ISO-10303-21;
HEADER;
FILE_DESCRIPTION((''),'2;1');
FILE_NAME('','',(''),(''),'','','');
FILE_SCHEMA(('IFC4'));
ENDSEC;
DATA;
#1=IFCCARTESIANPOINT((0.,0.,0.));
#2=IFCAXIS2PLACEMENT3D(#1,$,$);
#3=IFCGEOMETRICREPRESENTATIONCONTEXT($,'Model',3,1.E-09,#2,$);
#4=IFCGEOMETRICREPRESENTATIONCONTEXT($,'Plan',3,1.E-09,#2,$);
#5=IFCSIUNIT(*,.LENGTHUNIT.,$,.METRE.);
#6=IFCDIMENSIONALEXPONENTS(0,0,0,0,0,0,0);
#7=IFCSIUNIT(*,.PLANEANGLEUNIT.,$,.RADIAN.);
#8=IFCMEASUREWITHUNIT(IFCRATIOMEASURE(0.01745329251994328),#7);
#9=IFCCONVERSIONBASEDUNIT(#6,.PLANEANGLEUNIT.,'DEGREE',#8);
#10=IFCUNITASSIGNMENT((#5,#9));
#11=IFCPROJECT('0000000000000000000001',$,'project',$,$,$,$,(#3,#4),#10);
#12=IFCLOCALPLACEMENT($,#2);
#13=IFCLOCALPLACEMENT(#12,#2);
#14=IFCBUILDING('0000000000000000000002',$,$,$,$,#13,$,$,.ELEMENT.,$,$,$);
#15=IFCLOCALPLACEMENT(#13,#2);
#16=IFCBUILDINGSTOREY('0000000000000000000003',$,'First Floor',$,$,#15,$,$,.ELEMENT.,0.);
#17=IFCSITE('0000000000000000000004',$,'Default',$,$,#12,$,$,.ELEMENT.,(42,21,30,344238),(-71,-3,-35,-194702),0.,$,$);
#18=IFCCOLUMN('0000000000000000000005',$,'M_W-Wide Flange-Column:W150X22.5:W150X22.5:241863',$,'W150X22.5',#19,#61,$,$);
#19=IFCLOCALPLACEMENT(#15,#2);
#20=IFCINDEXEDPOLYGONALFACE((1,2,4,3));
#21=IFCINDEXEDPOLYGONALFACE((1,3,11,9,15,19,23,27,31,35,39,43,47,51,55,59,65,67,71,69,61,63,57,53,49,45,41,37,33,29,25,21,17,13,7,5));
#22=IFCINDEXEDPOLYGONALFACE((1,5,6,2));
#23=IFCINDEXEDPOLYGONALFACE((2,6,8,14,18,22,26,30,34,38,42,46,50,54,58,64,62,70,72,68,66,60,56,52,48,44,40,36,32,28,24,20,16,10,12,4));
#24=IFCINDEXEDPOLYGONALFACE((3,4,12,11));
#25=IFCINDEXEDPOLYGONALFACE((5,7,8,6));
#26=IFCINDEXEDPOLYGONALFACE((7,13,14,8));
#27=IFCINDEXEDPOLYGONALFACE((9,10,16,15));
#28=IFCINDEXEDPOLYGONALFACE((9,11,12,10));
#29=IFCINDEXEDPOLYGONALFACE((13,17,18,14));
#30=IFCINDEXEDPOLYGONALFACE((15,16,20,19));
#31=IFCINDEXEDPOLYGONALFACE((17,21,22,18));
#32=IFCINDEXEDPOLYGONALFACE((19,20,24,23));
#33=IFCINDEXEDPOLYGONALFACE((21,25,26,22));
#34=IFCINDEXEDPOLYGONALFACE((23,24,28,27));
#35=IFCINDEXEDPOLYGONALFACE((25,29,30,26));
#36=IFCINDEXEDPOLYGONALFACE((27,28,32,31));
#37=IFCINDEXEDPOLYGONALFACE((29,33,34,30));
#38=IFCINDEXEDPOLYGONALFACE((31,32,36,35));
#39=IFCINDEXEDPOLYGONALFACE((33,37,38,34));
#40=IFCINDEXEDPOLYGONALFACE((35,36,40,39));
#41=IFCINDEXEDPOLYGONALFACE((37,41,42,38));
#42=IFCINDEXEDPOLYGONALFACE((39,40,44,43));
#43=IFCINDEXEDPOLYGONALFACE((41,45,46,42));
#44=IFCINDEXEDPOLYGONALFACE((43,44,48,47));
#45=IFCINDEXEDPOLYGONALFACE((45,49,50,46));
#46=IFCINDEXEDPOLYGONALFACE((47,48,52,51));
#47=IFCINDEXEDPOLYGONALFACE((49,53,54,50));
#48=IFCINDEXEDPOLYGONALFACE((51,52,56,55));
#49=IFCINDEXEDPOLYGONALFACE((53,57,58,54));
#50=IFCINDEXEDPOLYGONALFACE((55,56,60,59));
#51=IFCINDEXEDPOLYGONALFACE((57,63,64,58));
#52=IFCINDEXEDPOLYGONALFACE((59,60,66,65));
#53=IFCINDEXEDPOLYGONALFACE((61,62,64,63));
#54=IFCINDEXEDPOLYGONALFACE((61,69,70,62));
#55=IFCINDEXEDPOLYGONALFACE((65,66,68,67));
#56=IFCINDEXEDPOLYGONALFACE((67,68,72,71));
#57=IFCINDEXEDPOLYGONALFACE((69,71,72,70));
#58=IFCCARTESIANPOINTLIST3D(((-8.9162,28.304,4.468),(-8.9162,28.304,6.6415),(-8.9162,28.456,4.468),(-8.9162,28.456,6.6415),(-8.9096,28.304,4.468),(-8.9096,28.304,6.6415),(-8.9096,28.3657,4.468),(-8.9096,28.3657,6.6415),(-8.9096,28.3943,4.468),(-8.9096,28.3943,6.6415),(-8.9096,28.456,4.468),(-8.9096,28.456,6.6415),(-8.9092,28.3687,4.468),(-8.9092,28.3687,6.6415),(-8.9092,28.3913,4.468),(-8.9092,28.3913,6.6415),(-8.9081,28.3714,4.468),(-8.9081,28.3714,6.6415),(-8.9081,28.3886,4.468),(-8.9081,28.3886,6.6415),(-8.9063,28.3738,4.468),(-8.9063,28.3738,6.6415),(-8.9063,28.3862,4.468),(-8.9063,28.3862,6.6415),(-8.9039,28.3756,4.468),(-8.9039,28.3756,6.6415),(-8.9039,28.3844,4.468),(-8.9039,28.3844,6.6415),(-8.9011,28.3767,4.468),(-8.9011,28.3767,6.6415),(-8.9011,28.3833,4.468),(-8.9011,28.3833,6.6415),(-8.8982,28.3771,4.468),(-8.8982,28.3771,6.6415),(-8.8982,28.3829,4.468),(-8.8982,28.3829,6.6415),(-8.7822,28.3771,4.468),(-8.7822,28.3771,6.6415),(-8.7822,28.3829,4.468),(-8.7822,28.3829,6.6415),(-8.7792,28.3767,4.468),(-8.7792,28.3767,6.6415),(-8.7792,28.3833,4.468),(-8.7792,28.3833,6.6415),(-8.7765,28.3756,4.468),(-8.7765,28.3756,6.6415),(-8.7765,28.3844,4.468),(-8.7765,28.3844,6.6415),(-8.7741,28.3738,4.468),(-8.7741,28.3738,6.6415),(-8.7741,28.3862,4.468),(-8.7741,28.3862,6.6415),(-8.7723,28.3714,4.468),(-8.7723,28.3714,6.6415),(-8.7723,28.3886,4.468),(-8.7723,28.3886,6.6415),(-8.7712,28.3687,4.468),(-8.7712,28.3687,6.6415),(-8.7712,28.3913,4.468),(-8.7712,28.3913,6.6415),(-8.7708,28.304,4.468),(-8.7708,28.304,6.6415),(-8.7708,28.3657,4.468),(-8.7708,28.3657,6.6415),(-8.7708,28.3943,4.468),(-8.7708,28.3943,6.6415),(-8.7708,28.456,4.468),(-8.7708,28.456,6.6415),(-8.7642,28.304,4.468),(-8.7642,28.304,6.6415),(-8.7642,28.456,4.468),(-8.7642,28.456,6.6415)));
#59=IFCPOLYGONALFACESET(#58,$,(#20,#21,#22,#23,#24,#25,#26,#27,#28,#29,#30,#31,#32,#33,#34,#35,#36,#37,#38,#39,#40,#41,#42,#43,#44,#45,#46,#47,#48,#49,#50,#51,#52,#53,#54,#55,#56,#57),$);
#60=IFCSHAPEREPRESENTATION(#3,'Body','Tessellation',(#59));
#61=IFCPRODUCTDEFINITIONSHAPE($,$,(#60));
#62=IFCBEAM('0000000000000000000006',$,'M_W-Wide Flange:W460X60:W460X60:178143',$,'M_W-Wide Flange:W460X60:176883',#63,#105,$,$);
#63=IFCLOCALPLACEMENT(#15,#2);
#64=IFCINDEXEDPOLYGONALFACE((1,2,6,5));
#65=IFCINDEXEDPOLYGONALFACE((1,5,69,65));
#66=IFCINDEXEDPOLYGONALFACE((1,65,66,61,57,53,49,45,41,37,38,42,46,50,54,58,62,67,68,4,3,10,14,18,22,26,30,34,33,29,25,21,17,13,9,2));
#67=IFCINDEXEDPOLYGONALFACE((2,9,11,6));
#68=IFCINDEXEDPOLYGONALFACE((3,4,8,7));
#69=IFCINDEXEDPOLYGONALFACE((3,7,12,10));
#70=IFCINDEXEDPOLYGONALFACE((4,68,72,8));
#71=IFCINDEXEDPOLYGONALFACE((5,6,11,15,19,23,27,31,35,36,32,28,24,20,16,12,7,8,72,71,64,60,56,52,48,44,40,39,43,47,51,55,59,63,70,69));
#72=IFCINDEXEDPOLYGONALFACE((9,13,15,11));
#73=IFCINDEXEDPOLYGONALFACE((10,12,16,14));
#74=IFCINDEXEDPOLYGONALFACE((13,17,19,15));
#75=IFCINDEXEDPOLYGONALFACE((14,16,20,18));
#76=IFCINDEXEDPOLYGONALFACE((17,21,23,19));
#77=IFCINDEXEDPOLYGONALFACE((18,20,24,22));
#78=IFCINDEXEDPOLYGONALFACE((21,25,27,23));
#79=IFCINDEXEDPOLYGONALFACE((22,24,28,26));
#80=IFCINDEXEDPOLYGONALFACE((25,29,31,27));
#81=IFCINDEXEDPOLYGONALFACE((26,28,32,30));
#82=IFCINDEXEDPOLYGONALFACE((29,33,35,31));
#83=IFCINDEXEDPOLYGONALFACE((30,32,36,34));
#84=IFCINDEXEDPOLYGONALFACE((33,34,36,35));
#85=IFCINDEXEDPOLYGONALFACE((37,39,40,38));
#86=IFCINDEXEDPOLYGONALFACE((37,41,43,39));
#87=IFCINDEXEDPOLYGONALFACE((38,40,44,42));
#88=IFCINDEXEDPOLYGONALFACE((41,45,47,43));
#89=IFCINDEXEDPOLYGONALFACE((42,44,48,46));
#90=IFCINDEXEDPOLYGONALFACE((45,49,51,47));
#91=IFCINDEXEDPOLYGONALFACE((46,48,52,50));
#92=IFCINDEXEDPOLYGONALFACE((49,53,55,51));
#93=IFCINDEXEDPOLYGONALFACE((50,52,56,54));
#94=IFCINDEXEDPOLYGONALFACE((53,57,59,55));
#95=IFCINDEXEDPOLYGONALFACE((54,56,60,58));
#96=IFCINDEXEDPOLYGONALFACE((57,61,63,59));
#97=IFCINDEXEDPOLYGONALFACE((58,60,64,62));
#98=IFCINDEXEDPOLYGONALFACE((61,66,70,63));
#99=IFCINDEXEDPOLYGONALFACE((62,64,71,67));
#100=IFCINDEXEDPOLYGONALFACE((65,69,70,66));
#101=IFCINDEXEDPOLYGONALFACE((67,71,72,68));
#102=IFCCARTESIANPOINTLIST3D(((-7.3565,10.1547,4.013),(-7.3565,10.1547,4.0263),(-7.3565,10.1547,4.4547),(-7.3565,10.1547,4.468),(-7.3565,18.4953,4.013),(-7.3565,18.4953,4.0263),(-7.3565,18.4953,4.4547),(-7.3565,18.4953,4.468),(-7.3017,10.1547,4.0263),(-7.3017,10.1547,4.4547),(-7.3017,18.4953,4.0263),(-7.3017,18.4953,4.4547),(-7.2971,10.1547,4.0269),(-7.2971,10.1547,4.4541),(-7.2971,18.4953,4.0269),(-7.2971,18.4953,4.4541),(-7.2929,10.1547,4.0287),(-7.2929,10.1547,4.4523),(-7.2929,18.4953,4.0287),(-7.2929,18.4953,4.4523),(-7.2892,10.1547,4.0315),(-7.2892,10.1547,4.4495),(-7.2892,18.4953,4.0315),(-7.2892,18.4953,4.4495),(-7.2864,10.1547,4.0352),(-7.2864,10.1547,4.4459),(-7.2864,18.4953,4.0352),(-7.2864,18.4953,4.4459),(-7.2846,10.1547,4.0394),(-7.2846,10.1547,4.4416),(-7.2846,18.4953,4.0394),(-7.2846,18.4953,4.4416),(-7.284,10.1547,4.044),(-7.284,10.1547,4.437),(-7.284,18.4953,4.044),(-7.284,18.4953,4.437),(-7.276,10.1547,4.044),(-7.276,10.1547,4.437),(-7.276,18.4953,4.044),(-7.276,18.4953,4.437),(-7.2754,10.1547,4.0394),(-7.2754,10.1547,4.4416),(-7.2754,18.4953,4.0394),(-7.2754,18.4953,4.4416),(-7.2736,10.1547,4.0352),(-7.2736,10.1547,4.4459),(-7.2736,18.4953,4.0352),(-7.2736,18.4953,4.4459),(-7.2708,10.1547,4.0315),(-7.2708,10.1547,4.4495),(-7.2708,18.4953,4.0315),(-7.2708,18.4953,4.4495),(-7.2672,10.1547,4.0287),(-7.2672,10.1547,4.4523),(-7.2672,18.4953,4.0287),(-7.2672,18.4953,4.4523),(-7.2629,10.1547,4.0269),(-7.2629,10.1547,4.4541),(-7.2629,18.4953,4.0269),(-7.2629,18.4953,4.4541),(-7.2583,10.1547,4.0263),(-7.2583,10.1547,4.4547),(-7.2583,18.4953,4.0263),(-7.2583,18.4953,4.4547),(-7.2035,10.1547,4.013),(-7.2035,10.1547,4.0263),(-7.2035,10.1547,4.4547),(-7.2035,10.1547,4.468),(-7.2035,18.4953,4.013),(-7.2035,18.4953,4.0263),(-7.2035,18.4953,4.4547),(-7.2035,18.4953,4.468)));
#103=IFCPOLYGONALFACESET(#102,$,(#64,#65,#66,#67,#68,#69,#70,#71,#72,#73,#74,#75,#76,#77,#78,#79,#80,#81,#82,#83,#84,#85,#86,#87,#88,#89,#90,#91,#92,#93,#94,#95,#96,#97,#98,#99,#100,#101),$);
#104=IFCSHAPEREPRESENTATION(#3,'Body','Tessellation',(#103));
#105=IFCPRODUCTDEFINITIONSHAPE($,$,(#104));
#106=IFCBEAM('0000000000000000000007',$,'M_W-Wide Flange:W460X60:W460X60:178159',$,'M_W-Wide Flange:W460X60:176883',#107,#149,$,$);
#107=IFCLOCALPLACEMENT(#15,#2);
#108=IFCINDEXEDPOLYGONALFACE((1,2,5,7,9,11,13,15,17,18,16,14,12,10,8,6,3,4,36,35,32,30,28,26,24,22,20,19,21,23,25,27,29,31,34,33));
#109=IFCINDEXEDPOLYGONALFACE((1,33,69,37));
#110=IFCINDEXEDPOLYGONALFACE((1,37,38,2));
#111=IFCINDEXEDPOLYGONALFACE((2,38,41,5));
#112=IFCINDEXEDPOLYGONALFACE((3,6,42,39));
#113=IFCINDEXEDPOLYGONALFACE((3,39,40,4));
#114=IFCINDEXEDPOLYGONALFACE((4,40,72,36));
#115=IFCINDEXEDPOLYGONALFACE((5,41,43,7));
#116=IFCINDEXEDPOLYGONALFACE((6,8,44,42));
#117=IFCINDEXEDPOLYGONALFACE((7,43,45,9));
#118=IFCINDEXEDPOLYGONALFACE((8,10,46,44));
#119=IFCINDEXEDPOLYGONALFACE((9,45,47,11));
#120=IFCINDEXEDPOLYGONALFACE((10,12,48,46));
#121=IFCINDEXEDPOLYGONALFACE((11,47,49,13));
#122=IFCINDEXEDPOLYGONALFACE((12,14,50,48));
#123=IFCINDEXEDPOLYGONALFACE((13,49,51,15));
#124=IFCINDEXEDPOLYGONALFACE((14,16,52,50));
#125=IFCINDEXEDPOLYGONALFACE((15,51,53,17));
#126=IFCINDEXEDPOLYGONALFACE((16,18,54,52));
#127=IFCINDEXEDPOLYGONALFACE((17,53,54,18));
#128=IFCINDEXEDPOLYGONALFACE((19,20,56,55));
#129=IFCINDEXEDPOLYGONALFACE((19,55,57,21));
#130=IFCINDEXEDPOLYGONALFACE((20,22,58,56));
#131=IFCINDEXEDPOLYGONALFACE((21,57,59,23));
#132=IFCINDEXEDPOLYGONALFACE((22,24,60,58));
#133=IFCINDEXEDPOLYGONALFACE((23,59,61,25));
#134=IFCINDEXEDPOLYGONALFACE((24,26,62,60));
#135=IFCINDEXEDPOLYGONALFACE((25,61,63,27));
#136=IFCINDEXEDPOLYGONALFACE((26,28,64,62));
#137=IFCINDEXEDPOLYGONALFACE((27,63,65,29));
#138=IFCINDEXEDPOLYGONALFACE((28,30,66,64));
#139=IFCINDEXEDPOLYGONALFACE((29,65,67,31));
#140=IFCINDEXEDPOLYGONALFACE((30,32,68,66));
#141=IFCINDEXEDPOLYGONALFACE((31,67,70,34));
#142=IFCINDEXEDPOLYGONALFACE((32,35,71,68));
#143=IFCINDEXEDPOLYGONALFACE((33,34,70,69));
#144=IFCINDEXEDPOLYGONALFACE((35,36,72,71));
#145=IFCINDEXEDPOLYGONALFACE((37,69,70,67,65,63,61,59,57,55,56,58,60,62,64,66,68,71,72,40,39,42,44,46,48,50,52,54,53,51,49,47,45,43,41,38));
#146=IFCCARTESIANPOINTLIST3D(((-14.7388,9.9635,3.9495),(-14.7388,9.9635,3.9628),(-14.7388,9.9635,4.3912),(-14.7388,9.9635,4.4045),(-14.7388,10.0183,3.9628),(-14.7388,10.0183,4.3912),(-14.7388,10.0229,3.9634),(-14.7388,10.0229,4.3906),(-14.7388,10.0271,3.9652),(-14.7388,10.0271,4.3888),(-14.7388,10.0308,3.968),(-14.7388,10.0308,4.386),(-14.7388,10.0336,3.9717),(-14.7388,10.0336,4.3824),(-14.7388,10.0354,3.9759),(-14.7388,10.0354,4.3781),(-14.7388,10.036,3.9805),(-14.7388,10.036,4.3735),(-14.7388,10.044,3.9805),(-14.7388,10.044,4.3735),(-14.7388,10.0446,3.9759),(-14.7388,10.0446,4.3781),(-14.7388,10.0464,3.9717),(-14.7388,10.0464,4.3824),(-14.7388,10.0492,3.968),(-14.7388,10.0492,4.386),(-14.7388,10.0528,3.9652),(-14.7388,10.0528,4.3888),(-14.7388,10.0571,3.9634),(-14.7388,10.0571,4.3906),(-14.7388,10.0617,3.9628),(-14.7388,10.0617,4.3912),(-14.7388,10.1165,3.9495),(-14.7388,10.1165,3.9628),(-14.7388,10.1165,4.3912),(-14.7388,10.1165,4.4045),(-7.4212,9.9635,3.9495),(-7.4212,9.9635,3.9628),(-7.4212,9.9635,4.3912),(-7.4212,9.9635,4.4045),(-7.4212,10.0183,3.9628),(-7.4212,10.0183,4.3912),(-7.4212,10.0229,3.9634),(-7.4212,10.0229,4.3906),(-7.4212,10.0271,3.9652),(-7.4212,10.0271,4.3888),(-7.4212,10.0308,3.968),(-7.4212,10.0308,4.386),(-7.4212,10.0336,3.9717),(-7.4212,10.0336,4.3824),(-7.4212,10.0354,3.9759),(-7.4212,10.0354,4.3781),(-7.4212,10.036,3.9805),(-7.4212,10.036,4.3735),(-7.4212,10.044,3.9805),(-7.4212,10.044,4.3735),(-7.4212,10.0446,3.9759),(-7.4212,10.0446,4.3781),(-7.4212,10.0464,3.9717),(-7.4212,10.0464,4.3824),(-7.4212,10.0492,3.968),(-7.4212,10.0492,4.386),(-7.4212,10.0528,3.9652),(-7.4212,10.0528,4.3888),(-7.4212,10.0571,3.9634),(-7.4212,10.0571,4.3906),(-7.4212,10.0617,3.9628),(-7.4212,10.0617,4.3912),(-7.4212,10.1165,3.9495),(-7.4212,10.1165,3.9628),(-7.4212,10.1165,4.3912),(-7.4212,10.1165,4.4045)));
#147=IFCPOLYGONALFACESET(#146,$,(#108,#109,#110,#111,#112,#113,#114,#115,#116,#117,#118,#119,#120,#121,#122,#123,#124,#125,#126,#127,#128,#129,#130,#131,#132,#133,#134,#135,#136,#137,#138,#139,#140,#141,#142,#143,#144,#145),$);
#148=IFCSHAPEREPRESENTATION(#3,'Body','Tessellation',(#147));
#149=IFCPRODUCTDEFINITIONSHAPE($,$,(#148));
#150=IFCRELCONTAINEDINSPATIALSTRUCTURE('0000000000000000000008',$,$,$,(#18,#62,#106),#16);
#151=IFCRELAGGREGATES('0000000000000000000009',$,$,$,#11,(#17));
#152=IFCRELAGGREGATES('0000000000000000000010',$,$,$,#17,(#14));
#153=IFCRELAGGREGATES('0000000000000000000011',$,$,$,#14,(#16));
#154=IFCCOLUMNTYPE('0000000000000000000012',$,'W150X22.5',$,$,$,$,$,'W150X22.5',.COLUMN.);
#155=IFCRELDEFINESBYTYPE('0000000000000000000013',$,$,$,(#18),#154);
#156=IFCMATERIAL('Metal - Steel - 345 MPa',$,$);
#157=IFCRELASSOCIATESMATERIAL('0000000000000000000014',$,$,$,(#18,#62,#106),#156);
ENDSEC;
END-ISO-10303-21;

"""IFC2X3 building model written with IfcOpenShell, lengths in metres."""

from ifc_helpers import new_model, entity, si_unit, converted_unit, frame, frame_2d, origin, place, context, project, spatial, polyline, circle_curve, parameter, trimmed, segment, composite_curve, outline, extrude, source, transform, mapped, material, type_object, type_shapes, element, save


model = new_model("IFC2X3")

# Units and contexts
model_context = context("Model", 3, precision=1e-09, world=origin())
plan_context = context("Plan", 3, precision=1e-09, world=origin())
ifc_project = project(units=[si_unit("LENGTHUNIT", "METRE"), converted_unit("PLANEANGLEUNIT", "DEGREE", entity("IfcRatioMeasure", 0.01745329251994328), si_unit("PLANEANGLEUNIT", "RADIAN"), dimensions=[0, 0, 0, 0, 0, 0, 0])], contexts=[model_context, plan_context])

# Site, building, storey
site_placement = place(None, origin())
site = spatial("IfcSite", under=ifc_project, at=site_placement, Name="Default", CompositionType="ELEMENT", RefLatitude=(42, 21, 30, 344238), RefLongitude=(-71, -3, -35, -194702), RefElevation=0.0)
building_placement = place(site_placement, origin())
building = spatial("IfcBuilding", under=site, at=building_placement, CompositionType="ELEMENT")
storey_placement = place(building_placement, origin())
storey = spatial("IfcBuildingStorey", under=building, at=storey_placement, Name="First Floor", CompositionType="ELEMENT", Elevation=0.0)

# Column
ifc_material = material(Name="Metal - Steel - 345 MPa")
column_type = type_object("IfcColumnType", Name="W150X22.5", ElementType="W150X22.5", PredefinedType="COLUMN")
shared_shape = source(origin(), model_context, "Body", "SweptSolid", [
    extrude(outline(composite_curve([segment(polyline([(-0.076, -0.076), (0.076, -0.076)]), True, "CONTINUOUS"), segment(polyline([(0.076, -0.076), (0.076, -0.0694)]), True, "CONTINUOUS"), segment(polyline([(0.076, -0.0694), (0.0143, -0.0694)]), True, "CONTINUOUS"), segment(trimmed(circle_curve(frame_2d((0.0143, -0.058), x_axis=(-1.0, 0.0)), 0.0114), [parameter(0.0)], [parameter(90.0)], True, "PARAMETER"), False, "CONTINUOUS"), segment(polyline([(0.0029, -0.058), (0.0029, 0.058)]), True, "CONTINUOUS"), segment(trimmed(circle_curve(frame_2d((0.0143, 0.058), x_axis=(-1.0, 0.0)), 0.0114), [parameter(270.0)], [parameter(0.0)], True, "PARAMETER"), False, "CONTINUOUS"), segment(polyline([(0.0143, 0.0694), (0.076, 0.0694)]), True, "CONTINUOUS"), segment(polyline([(0.076, 0.0694), (0.076, 0.076)]), True, "CONTINUOUS"), segment(polyline([(0.076, 0.076), (-0.076, 0.076)]), True, "CONTINUOUS"), segment(polyline([(-0.076, 0.076), (-0.076, 0.0694)]), True, "CONTINUOUS"), segment(polyline([(-0.076, 0.0694), (-0.0143, 0.0694)]), True, "CONTINUOUS"), segment(trimmed(circle_curve(frame_2d((-0.0143, 0.058), x_axis=(-1.0, 0.0)), 0.0114), [parameter(180.0)], [parameter(270.0)], True, "PARAMETER"), False, "CONTINUOUS"), segment(polyline([(-0.0029, 0.058), (-0.0029, -0.058)]), True, "CONTINUOUS"), segment(trimmed(circle_curve(frame_2d((-0.0143, -0.058), x_axis=(-1.0, 0.0)), 0.0114), [parameter(90.0)], [parameter(180.0)], True, "PARAMETER"), False, "CONTINUOUS"), segment(polyline([(-0.0143, -0.0694), (-0.076, -0.0694)]), True, "CONTINUOUS"), segment(polyline([(-0.076, -0.0694), (-0.076, -0.076)]), True, "CONTINUOUS")], self_intersect=False)), frame((0.0, 0.0, 4.468), z_axis=(0.0, 0.0, 1.0), x_axis=(-1.0, 0.0, 0.0)), (0.0, 0.0, 1.0), 2.1735),
])
type_shapes(column_type, [shared_shape])
column_placement = place(storey_placement, frame((-8.8402, 28.38, 0.0), z_axis=(0.0, 0.0, 1.0), x_axis=(0.0, 1.0, 0.0)))
element("IfcColumn", 1, at=column_placement, inside=storey, type_object=column_type, material=ifc_material, Name="M_W-Wide Flange-Column:W150X22.5:W150X22.5:241863", ObjectType="W150X22.5", context=model_context, shape_type="MappedRepresentation", body=[
    mapped(shared_shape, transform((0.0, 0.0, 0.0), scale=1.0)),
])

# Beams
beam_1_placement = place(storey_placement, frame((-7.28, 18.6116, 4.468), z_axis=(0.0, 0.0, 1.0), x_axis=(-1.0, 0.0, 0.0)))
element("IfcBeam", 2, at=beam_1_placement, inside=storey, material=ifc_material, Name="M_W-Wide Flange:W460X60:W460X60:178143", ObjectType="M_W-Wide Flange:W460X60:176883", context=model_context, shape_type="SweptSolid", body=[
    extrude(outline(composite_curve([segment(polyline([(0.2142, -0.0765), (0.2275, -0.0765)]), True, "CONTINUOUS"), segment(polyline([(0.2275, -0.0765), (0.2275, 0.0765)]), True, "CONTINUOUS"), segment(polyline([(0.2275, 0.0765), (0.2142, 0.0765)]), True, "CONTINUOUS"), segment(polyline([(0.2142, 0.0765), (0.2142, 0.0217)]), True, "CONTINUOUS"), segment(trimmed(circle_curve(frame_2d((0.1965, 0.0217), x_axis=(1.0, 0.0)), 0.0177), [parameter(270.0)], [parameter(360.0)], True, "PARAMETER"), False, "CONTINUOUS"), segment(polyline([(0.1965, 0.004), (-0.1965, 0.004)]), True, "CONTINUOUS"), segment(trimmed(circle_curve(frame_2d((-0.1965, 0.0217), x_axis=(0.0, -1.0)), 0.0177), [parameter(270.0)], [parameter(360.0)], True, "PARAMETER"), False, "CONTINUOUS"), segment(polyline([(-0.2142, 0.0217), (-0.2142, 0.0765)]), True, "CONTINUOUS"), segment(polyline([(-0.2142, 0.0765), (-0.2275, 0.0765)]), True, "CONTINUOUS"), segment(polyline([(-0.2275, 0.0765), (-0.2275, -0.0765)]), True, "CONTINUOUS"), segment(polyline([(-0.2275, -0.0765), (-0.2142, -0.0765)]), True, "CONTINUOUS"), segment(polyline([(-0.2142, -0.0765), (-0.2142, -0.0217)]), True, "CONTINUOUS"), segment(trimmed(circle_curve(frame_2d((-0.1965, -0.0217), x_axis=(-1.0, 0.0)), 0.0177), [parameter(270.0)], [parameter(360.0)], True, "PARAMETER"), False, "CONTINUOUS"), segment(polyline([(-0.1965, -0.004), (0.1965, -0.004)]), True, "CONTINUOUS"), segment(trimmed(circle_curve(frame_2d((0.1965, -0.0217), x_axis=(0.0, 1.0)), 0.0177), [parameter(270.0)], [parameter(0.0)], True, "PARAMETER"), False, "CONTINUOUS"), segment(polyline([(0.2142, -0.0217), (0.2142, -0.0765)]), True, "CONTINUOUS")], self_intersect=False)), frame((0.0, 8.4569, -0.2275), z_axis=(0.0, -1.0, 0.0), x_axis=(0.0, 0.0, -1.0)), (0.0, 0.0, 1.0), 8.3406),
])
beam_2_placement = place(storey_placement, frame((-7.2782, 10.04, 4.4045), z_axis=(0.0, 0.0, 1.0), x_axis=(0.0, 1.0, 0.0)))
element("IfcBeam", 3, at=beam_2_placement, inside=storey, material=ifc_material, Name="M_W-Wide Flange:W460X60:W460X60:178159", ObjectType="M_W-Wide Flange:W460X60:176883", context=model_context, shape_type="SweptSolid", body=[
    extrude(outline(composite_curve([segment(polyline([(0.2142, -0.0765), (0.2275, -0.0765)]), True, "CONTINUOUS"), segment(polyline([(0.2275, -0.0765), (0.2275, 0.0765)]), True, "CONTINUOUS"), segment(polyline([(0.2275, 0.0765), (0.2142, 0.0765)]), True, "CONTINUOUS"), segment(polyline([(0.2142, 0.0765), (0.2142, 0.0217)]), True, "CONTINUOUS"), segment(trimmed(circle_curve(frame_2d((0.1965, 0.0217), x_axis=(1.0, 0.0)), 0.0177), [parameter(270.0)], [parameter(360.0)], True, "PARAMETER"), False, "CONTINUOUS"), segment(polyline([(0.1965, 0.004), (-0.1965, 0.004)]), True, "CONTINUOUS"), segment(trimmed(circle_curve(frame_2d((-0.1965, 0.0217), x_axis=(0.0, -1.0)), 0.0177), [parameter(270.0)], [parameter(360.0)], True, "PARAMETER"), False, "CONTINUOUS"), segment(polyline([(-0.2142, 0.0217), (-0.2142, 0.0765)]), True, "CONTINUOUS"), segment(polyline([(-0.2142, 0.0765), (-0.2275, 0.0765)]), True, "CONTINUOUS"), segment(polyline([(-0.2275, 0.0765), (-0.2275, -0.0765)]), True, "CONTINUOUS"), segment(polyline([(-0.2275, -0.0765), (-0.2142, -0.0765)]), True, "CONTINUOUS"), segment(polyline([(-0.2142, -0.0765), (-0.2142, -0.0217)]), True, "CONTINUOUS"), segment(trimmed(circle_curve(frame_2d((-0.1965, -0.0217), x_axis=(-1.0, 0.0)), 0.0177), [parameter(270.0)], [parameter(360.0)], True, "PARAMETER"), False, "CONTINUOUS"), segment(polyline([(-0.1965, -0.004), (0.1965, -0.004)]), True, "CONTINUOUS"), segment(trimmed(circle_curve(frame_2d((0.1965, -0.0217), x_axis=(0.0, 1.0)), 0.0177), [parameter(270.0)], [parameter(0.0)], True, "PARAMETER"), False, "CONTINUOUS"), segment(polyline([(0.2142, -0.0217), (0.2142, -0.0765)]), True, "CONTINUOUS")], self_intersect=False)), frame((0.0, 7.4606, -0.2275), z_axis=(0.0, -1.0, 0.0), x_axis=(0.0, 0.0, -1.0)), (0.0, 0.0, 1.0), 7.3176),
])

save(model, "model.ifc")
